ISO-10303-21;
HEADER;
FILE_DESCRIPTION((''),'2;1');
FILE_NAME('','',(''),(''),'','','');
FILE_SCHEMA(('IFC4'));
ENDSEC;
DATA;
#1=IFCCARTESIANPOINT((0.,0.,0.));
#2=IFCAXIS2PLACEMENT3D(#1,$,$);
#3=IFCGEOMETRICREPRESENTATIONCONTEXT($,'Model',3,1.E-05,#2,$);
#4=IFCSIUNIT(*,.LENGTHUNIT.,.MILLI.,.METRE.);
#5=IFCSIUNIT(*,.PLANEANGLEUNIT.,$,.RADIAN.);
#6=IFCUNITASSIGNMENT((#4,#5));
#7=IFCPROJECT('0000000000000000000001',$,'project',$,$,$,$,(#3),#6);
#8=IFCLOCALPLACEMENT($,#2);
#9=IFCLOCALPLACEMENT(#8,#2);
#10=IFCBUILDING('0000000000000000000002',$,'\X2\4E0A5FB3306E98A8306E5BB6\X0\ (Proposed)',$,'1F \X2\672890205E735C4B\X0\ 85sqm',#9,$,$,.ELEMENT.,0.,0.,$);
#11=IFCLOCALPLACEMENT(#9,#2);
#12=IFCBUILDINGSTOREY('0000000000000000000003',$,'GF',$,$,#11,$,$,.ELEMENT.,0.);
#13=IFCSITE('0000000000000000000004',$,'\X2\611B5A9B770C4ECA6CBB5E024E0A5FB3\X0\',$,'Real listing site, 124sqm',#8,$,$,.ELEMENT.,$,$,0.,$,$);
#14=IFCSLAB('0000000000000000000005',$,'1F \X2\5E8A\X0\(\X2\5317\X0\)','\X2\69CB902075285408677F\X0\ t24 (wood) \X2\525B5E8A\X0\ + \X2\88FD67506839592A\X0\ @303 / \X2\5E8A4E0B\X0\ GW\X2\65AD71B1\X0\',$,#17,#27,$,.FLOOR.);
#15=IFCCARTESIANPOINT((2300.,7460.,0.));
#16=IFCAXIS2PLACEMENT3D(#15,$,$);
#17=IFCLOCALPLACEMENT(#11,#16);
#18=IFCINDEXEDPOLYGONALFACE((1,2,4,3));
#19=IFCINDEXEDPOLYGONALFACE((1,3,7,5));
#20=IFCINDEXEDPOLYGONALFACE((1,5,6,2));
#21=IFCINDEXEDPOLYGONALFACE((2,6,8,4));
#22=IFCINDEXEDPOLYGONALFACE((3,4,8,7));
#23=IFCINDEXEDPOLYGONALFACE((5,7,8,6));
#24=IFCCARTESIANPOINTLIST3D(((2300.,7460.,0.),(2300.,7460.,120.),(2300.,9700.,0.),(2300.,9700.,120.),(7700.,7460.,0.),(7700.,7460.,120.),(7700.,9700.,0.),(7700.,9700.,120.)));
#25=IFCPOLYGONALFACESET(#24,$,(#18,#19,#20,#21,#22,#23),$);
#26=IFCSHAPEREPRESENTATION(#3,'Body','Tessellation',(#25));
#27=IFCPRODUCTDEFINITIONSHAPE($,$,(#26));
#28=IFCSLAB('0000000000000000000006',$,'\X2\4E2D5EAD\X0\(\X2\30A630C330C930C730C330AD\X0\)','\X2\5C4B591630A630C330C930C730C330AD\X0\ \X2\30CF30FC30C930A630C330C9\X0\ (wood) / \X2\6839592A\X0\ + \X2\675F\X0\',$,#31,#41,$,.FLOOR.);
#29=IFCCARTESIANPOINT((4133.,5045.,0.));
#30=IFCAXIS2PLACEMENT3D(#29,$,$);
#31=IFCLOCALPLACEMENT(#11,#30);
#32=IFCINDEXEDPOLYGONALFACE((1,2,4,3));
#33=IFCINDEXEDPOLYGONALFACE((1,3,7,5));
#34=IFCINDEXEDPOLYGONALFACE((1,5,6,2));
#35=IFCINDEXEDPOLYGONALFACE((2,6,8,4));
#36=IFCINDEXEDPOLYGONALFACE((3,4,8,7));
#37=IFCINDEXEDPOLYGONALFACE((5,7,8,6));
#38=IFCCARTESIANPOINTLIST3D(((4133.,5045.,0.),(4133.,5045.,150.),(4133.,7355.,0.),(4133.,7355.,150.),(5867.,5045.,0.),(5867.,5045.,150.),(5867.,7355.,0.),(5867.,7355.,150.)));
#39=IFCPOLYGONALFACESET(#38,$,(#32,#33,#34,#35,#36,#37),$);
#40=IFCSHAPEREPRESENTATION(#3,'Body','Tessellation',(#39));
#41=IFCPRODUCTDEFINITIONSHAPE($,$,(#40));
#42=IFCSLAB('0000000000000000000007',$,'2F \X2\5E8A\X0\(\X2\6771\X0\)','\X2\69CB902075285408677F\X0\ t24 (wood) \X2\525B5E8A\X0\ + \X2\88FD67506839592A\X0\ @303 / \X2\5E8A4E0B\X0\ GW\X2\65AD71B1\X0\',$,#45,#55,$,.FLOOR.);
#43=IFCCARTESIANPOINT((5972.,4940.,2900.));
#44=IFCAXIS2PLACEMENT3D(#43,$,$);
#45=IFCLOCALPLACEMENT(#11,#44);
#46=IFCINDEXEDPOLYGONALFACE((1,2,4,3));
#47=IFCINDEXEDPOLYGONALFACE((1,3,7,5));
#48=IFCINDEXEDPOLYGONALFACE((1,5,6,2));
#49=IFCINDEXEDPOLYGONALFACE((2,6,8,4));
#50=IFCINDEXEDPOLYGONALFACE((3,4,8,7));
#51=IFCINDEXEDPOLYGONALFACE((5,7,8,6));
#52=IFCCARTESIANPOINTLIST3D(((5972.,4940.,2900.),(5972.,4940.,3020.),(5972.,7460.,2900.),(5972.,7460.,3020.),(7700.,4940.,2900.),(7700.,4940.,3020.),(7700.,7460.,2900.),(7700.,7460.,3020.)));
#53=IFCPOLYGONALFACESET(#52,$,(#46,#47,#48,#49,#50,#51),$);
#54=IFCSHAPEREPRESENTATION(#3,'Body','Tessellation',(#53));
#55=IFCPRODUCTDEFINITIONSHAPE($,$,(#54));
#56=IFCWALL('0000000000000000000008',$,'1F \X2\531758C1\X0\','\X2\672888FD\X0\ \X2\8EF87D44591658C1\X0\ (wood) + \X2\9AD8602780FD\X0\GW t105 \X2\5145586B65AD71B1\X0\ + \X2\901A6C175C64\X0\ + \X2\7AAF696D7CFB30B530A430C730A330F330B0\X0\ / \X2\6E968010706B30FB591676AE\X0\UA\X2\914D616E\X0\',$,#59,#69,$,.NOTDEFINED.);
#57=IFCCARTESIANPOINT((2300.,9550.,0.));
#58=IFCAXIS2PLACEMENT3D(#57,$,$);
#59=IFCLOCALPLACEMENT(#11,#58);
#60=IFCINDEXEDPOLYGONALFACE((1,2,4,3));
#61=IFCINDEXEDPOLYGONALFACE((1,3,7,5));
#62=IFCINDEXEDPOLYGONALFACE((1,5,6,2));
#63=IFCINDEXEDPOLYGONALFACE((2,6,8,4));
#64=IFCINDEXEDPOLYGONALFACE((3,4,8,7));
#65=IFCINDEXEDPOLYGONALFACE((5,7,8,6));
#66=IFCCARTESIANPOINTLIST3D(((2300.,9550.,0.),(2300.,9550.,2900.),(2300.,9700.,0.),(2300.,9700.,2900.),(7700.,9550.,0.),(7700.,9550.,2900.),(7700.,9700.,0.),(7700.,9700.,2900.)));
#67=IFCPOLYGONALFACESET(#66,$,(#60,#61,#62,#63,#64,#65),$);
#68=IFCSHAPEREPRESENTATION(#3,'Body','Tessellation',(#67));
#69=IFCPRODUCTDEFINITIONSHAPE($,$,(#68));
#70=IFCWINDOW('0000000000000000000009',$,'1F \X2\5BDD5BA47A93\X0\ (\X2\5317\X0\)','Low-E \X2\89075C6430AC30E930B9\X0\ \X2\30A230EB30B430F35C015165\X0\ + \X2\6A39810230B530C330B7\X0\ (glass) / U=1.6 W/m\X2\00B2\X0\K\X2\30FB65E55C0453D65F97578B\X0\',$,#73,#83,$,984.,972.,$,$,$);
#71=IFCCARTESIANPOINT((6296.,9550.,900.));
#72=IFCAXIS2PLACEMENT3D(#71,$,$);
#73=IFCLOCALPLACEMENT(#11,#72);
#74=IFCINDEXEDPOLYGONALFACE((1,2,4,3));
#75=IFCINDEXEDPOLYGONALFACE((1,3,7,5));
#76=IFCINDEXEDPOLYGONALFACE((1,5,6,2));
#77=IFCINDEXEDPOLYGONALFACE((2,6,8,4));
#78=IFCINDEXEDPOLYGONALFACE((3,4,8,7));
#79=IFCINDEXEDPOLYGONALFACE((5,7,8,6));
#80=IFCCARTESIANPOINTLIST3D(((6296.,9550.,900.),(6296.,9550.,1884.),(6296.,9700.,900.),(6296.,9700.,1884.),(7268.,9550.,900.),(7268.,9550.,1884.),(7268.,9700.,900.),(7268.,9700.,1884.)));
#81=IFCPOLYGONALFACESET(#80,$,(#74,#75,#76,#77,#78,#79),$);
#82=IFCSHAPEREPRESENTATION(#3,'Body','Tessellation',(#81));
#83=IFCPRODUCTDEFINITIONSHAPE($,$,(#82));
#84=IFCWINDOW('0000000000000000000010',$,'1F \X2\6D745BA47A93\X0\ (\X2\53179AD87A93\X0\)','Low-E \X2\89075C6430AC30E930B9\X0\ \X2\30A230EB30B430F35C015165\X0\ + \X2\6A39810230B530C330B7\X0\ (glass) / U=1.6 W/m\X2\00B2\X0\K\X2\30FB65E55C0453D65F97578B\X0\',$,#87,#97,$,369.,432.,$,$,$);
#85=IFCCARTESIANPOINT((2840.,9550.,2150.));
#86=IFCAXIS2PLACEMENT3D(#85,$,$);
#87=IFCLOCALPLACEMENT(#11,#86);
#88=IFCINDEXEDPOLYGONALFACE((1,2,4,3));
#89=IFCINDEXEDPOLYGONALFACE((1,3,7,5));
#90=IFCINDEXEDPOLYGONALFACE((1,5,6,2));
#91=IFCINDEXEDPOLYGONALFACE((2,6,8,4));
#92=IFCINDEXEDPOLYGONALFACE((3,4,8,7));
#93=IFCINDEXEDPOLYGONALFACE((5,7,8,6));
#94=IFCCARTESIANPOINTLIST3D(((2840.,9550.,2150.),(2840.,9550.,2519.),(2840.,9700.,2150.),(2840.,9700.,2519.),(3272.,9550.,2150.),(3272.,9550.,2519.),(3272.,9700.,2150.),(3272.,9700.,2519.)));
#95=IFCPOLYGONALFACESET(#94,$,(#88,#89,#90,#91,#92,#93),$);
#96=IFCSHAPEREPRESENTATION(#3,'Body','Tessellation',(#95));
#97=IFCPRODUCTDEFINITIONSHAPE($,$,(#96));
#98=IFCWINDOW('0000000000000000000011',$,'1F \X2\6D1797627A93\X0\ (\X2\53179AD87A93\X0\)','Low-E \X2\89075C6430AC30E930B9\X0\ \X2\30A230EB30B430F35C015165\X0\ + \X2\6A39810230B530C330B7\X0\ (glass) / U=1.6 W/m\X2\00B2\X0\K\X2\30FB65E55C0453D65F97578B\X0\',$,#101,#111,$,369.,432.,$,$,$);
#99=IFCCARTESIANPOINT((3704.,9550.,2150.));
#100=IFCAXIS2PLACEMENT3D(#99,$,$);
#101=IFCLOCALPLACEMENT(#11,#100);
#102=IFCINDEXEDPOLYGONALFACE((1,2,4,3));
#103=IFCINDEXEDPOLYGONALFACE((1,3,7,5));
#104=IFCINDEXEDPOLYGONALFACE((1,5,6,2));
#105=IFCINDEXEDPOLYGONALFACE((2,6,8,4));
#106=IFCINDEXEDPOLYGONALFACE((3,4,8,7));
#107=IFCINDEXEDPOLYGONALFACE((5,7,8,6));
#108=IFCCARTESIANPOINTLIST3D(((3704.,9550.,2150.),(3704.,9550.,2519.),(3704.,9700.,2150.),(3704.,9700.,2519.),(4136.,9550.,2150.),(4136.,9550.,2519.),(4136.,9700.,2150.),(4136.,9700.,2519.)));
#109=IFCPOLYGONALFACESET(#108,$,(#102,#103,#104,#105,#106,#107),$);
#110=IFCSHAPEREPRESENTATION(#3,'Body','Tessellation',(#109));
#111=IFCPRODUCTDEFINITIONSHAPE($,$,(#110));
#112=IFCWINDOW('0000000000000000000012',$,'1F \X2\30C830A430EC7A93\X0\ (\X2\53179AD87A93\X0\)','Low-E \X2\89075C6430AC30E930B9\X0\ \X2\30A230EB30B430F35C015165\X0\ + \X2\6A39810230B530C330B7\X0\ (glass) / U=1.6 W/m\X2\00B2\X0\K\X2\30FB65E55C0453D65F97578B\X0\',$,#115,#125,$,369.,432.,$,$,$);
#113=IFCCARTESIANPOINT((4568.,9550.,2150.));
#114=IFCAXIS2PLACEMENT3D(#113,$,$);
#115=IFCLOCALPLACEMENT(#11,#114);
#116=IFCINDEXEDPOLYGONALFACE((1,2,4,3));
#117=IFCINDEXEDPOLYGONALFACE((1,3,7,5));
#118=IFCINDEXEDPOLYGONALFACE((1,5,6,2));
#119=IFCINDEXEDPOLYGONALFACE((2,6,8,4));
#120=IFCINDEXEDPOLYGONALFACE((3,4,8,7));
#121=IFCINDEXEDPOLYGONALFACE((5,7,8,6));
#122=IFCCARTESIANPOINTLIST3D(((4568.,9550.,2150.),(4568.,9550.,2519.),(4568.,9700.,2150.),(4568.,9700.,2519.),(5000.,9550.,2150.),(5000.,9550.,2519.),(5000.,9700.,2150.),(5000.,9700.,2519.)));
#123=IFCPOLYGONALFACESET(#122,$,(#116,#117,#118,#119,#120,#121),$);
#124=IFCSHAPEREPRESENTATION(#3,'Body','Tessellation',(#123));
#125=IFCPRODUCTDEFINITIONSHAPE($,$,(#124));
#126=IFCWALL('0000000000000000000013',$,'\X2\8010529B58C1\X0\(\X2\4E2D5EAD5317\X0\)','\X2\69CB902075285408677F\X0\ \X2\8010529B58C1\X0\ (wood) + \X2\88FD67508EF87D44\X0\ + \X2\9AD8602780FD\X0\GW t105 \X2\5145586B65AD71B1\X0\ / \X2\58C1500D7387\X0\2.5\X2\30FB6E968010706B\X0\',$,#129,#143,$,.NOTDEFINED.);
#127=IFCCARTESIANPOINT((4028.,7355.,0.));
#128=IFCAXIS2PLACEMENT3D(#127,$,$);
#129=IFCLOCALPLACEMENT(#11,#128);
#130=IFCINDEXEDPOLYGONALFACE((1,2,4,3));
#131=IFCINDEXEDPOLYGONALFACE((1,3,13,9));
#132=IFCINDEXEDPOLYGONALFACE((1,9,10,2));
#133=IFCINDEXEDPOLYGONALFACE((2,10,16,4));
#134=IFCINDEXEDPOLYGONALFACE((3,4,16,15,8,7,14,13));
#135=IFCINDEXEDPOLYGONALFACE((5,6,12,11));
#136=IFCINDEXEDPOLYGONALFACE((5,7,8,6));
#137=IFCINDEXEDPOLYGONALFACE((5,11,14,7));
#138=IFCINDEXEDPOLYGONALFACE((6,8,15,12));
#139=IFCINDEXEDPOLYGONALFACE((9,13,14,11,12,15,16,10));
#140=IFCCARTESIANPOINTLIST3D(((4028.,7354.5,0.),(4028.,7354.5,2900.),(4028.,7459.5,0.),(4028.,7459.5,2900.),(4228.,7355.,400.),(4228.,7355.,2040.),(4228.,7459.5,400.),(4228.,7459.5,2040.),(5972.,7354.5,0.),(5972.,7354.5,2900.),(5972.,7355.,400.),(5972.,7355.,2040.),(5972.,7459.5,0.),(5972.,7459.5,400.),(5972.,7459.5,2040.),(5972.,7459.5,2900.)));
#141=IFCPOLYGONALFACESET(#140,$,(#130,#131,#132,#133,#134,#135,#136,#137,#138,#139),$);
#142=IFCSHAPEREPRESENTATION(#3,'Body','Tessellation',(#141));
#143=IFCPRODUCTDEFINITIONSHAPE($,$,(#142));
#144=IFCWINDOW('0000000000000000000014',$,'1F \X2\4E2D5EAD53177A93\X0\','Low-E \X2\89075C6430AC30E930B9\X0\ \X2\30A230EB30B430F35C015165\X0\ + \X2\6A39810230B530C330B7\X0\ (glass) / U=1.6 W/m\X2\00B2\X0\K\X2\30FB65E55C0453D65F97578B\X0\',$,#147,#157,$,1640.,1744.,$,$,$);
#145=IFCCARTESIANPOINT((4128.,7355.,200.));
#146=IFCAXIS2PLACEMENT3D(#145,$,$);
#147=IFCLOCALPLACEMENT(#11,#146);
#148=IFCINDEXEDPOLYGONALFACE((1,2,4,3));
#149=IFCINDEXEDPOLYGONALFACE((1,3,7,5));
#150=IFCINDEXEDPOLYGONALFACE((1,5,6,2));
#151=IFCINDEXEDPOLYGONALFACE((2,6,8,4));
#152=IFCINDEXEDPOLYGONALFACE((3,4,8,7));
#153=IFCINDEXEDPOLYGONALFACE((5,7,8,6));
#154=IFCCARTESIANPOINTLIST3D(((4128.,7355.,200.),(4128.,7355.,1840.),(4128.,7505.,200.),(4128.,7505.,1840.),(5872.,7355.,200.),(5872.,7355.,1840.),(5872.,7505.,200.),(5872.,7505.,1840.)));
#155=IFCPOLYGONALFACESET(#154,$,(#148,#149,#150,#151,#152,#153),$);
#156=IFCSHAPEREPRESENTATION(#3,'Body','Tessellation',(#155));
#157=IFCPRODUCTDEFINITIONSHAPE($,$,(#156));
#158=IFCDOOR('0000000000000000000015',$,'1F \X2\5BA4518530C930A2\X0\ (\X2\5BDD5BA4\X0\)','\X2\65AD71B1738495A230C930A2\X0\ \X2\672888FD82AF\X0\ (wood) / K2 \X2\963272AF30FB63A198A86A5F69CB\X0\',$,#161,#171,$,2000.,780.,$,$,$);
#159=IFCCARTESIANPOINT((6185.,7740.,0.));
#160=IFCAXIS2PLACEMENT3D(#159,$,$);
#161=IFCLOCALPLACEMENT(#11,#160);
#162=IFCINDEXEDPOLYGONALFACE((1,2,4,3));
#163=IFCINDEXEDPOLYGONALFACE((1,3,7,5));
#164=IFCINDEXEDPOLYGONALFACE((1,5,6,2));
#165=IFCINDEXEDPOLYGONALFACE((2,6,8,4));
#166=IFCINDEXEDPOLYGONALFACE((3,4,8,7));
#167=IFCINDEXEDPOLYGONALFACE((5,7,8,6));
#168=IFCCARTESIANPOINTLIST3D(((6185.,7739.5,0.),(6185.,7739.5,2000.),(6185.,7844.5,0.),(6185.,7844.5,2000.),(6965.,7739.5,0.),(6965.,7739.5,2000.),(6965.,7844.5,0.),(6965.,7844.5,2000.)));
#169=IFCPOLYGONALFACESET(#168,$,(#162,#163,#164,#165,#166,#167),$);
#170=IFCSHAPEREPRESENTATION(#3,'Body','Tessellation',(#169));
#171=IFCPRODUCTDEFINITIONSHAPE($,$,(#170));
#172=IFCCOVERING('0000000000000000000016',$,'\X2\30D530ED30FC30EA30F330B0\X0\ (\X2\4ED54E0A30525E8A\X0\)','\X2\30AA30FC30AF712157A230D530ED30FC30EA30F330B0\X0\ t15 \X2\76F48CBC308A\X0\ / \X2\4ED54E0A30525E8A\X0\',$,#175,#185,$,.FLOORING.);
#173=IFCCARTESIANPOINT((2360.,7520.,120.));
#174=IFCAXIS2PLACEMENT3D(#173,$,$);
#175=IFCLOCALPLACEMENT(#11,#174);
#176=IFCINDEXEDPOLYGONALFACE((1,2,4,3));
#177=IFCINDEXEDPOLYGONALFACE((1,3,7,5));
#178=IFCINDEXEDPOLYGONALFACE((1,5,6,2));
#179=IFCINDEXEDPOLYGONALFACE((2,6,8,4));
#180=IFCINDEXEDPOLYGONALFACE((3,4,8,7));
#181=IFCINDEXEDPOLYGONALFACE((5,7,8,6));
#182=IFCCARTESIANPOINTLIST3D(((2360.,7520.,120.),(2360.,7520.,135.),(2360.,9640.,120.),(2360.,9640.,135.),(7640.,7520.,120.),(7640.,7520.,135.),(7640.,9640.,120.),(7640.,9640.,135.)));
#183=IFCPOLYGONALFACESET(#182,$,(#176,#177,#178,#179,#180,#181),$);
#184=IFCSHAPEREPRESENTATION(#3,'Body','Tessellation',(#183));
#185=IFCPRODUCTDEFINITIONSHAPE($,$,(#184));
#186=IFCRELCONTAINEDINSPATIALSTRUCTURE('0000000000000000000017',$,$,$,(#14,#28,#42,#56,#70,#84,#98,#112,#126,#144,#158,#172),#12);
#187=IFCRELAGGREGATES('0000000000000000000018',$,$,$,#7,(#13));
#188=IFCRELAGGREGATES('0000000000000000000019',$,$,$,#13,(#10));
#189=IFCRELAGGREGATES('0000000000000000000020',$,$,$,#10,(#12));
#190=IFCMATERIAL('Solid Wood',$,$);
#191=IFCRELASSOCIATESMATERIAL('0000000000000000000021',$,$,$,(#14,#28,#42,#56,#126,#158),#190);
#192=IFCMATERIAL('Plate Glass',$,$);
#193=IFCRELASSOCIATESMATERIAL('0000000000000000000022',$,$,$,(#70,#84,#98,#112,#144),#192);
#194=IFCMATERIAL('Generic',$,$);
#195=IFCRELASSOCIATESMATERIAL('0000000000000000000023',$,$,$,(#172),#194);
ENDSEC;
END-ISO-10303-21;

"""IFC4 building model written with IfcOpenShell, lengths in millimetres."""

from ifc_helpers import new_model, si_unit, frame, frame_2d, origin, place, context, project, spatial, rectangle, extrude, material, element, fill, save


model = new_model("IFC4")

# Units and contexts
model_context = context("Model", 3, precision=1e-05, world=origin())
ifc_project = project(units=[si_unit("LENGTHUNIT", "METRE", prefix="MILLI"), si_unit("PLANEANGLEUNIT", "RADIAN")], contexts=[model_context])

# Site, building, storey
site_placement = place(None, origin())
site = spatial("IfcSite", under=ifc_project, at=site_placement, Name="愛媛県今治市上徳", ObjectType="Real listing site, 124sqm", CompositionType="ELEMENT", RefElevation=0.0)
building_placement = place(site_placement, origin())
building = spatial("IfcBuilding", under=site, at=building_placement, Name="上徳の風の家 (Proposed)", ObjectType="1F 木造平屋 85sqm", CompositionType="ELEMENT", ElevationOfRefHeight=0.0, ElevationOfTerrain=0.0)
storey_placement = place(building_placement, origin())
storey = spatial("IfcBuildingStorey", under=building, at=storey_placement, Name="GF", CompositionType="ELEMENT", Elevation=0.0)

# Slabs
ifc_material_1 = material(Name="Solid Wood")
slab_1_placement = place(storey_placement, frame((2300.0, 7460.0, 0.0)))
element("IfcSlab", 1, at=slab_1_placement, inside=storey, material=ifc_material_1, Name="1F 床(北)", Description="構造用合板 t24 (wood) 剛床 + 製材根太 @303 / 床下 GW断熱", PredefinedType="FLOOR", context=model_context, shape_type="SweptSolid", body=[
    extrude(rectangle(XDim=5400.0, YDim=2240.0, at=frame_2d((2700.0, 1120.0))), frame((2300.0, 7460.0, 0.0)), (0.0, 0.0, 1.0), 120.0),
])
slab_2_placement = place(storey_placement, frame((4133.0, 5045.0, 0.0)))
element("IfcSlab", 2, at=slab_2_placement, inside=storey, material=ifc_material_1, Name="中庭(ウッドデッキ)", Description="屋外ウッドデッキ ハードウッド (wood) / 根太 + 束", PredefinedType="FLOOR", context=model_context, shape_type="SweptSolid", body=[
    extrude(rectangle(XDim=1734.0, YDim=2310.0, at=frame_2d((867.0, 1155.0))), frame((4133.0, 5045.0, 0.0)), (0.0, 0.0, 1.0), 150.0),
])
slab_3_placement = place(storey_placement, frame((5972.0, 4940.0, 2900.0)))
element("IfcSlab", 3, at=slab_3_placement, inside=storey, material=ifc_material_1, Name="2F 床(東)", Description="構造用合板 t24 (wood) 剛床 + 製材根太 @303 / 床下 GW断熱", PredefinedType="FLOOR", context=model_context, shape_type="SweptSolid", body=[
    extrude(rectangle(XDim=1728.0, YDim=2520.0, at=frame_2d((864.0, 1260.0))), frame((5972.0, 4940.0, 2900.0)), (0.0, 0.0, 1.0), 120.0),
])

# Wall, openings, windows
wall_1_placement = place(storey_placement, frame((2300.0, 9550.0, 0.0)))
wall_1 = element("IfcWall", 4, at=wall_1_placement, inside=storey, material=ifc_material_1, Name="1F 北壁", Description="木製 軸組外壁 (wood) + 高性能GW t105 充填断熱 + 通気層 + 窯業系サイディング / 準耐火・外皮UA配慮", PredefinedType="NOTDEFINED", context=model_context, shape_type="SweptSolid", body=[
    extrude(rectangle(XDim=5400.0, YDim=150.0, at=frame_2d((2700.0, 75.0))), frame((2300.0, 9550.0, 0.0)), (0.0, 0.0, 1.0), 2900.0),
])
opening_1_placement = place(storey_placement, frame((6296.0, 9550.0, 900.0)))
opening_1 = element("IfcOpeningElement", 5, at=opening_1_placement, cuts=wall_1, PredefinedType="NOTDEFINED", context=model_context, shape_type="SweptSolid", body=[
    extrude(rectangle(XDim=972.0, YDim=150.0, at=frame_2d((486.0, 75.0))), frame((6296.0, 9550.0, 900.0)), (0.0, 0.0, 1.0), 984.0),
])
opening_2_placement = place(storey_placement, frame((2840.0, 9550.0, 2150.0)))
opening_2 = element("IfcOpeningElement", 6, at=opening_2_placement, cuts=wall_1, PredefinedType="NOTDEFINED", context=model_context, shape_type="SweptSolid", body=[
    extrude(rectangle(XDim=432.0, YDim=150.0, at=frame_2d((216.0, 75.0))), frame((2840.0, 9550.0, 2150.0)), (0.0, 0.0, 1.0), 369.0),
])
opening_3_placement = place(storey_placement, frame((3704.0, 9550.0, 2150.0)))
opening_3 = element("IfcOpeningElement", 7, at=opening_3_placement, cuts=wall_1, PredefinedType="NOTDEFINED", context=model_context, shape_type="SweptSolid", body=[
    extrude(rectangle(XDim=432.0, YDim=150.0, at=frame_2d((216.0, 75.0))), frame((3704.0, 9550.0, 2150.0)), (0.0, 0.0, 1.0), 369.0),
])
opening_4_placement = place(storey_placement, frame((4568.0, 9550.0, 2150.0)))
opening_4 = element("IfcOpeningElement", 8, at=opening_4_placement, cuts=wall_1, PredefinedType="NOTDEFINED", context=model_context, shape_type="SweptSolid", body=[
    extrude(rectangle(XDim=432.0, YDim=150.0, at=frame_2d((216.0, 75.0))), frame((4568.0, 9550.0, 2150.0)), (0.0, 0.0, 1.0), 369.0),
])
ifc_material_2 = material(Name="Plate Glass")
window_1_placement = place(storey_placement, frame((6296.0, 9550.0, 900.0)))
window_1 = element("IfcWindow", 9, at=window_1_placement, inside=storey, material=ifc_material_2, Name="1F 寝室窓 (北)", Description="Low-E 複層ガラス アルゴン封入 + 樹脂サッシ (glass) / U=1.6 W/m²K・日射取得型", OverallHeight=984.0, OverallWidth=972.0, context=model_context, shape_type="SweptSolid", body=[
    extrude(rectangle(XDim=972.0, YDim=150.0, at=frame_2d((486.0, 75.0))), frame((6296.0, 9550.0, 900.0)), (0.0, 0.0, 1.0), 984.0),
])
fill(opening_1, window_1)
window_2_placement = place(storey_placement, frame((2840.0, 9550.0, 2150.0)))
window_2 = element("IfcWindow", 10, at=window_2_placement, inside=storey, material=ifc_material_2, Name="1F 浴室窓 (北高窓)", Description="Low-E 複層ガラス アルゴン封入 + 樹脂サッシ (glass) / U=1.6 W/m²K・日射取得型", OverallHeight=369.0, OverallWidth=432.0, context=model_context, shape_type="SweptSolid", body=[
    extrude(rectangle(XDim=432.0, YDim=150.0, at=frame_2d((216.0, 75.0))), frame((2840.0, 9550.0, 2150.0)), (0.0, 0.0, 1.0), 369.0),
])
fill(opening_2, window_2)
window_3_placement = place(storey_placement, frame((3704.0, 9550.0, 2150.0)))
window_3 = element("IfcWindow", 11, at=window_3_placement, inside=storey, material=ifc_material_2, Name="1F 洗面窓 (北高窓)", Description="Low-E 複層ガラス アルゴン封入 + 樹脂サッシ (glass) / U=1.6 W/m²K・日射取得型", OverallHeight=369.0, OverallWidth=432.0, context=model_context, shape_type="SweptSolid", body=[
    extrude(rectangle(XDim=432.0, YDim=150.0, at=frame_2d((216.0, 75.0))), frame((3704.0, 9550.0, 2150.0)), (0.0, 0.0, 1.0), 369.0),
])
fill(opening_3, window_3)
window_4_placement = place(storey_placement, frame((4568.0, 9550.0, 2150.0)))
window_4 = element("IfcWindow", 12, at=window_4_placement, inside=storey, material=ifc_material_2, Name="1F トイレ窓 (北高窓)", Description="Low-E 複層ガラス アルゴン封入 + 樹脂サッシ (glass) / U=1.6 W/m²K・日射取得型", OverallHeight=369.0, OverallWidth=432.0, context=model_context, shape_type="SweptSolid", body=[
    extrude(rectangle(XDim=432.0, YDim=150.0, at=frame_2d((216.0, 75.0))), frame((4568.0, 9550.0, 2150.0)), (0.0, 0.0, 1.0), 369.0),
])
fill(opening_4, window_4)

# Wall, opening, window
wall_2_placement = place(storey_placement, frame((4028.0, 7355.0, 0.0)))
wall_2 = element("IfcWall", 13, at=wall_2_placement, inside=storey, material=ifc_material_1, Name="耐力壁(中庭北)", Description="構造用合板 耐力壁 (wood) + 製材軸組 + 高性能GW t105 充填断熱 / 壁倍率2.5・準耐火", PredefinedType="NOTDEFINED", context=model_context, shape_type="SweptSolid", body=[
    extrude(rectangle(XDim=1944.0, YDim=105.0, at=frame_2d((972.0, 52.0))), frame((4028.0, 7355.0, 0.0)), (0.0, 0.0, 1.0), 2900.0),
])
opening_5_placement = place(storey_placement, frame((4128.0, 7355.0, 200.0)))
opening_5 = element("IfcOpeningElement", 14, at=opening_5_placement, cuts=wall_2, PredefinedType="NOTDEFINED", context=model_context, shape_type="SweptSolid", body=[
    extrude(rectangle(XDim=1744.0, YDim=150.0, at=frame_2d((872.0, 75.0))), frame((4128.0, 7355.0, 200.0)), (0.0, 0.0, 1.0), 1640.0),
])
window_5_placement = place(storey_placement, frame((4128.0, 7355.0, 200.0)))
window_5 = element("IfcWindow", 15, at=window_5_placement, inside=storey, material=ifc_material_2, Name="1F 中庭北窓", Description="Low-E 複層ガラス アルゴン封入 + 樹脂サッシ (glass) / U=1.6 W/m²K・日射取得型", OverallHeight=1640.0, OverallWidth=1744.0, context=model_context, shape_type="SweptSolid", body=[
    extrude(rectangle(XDim=1744.0, YDim=150.0, at=frame_2d((872.0, 75.0))), frame((4128.0, 7355.0, 200.0)), (0.0, 0.0, 1.0), 1640.0),
])
fill(opening_5, window_5)

# Door
door_1_placement = place(storey_placement, frame((6185.0, 7740.0, 0.0)))
element("IfcDoor", 16, at=door_1_placement, inside=storey, material=ifc_material_1, Name="1F 室内ドア (寝室)", Description="断熱玄関ドア 木製芯 (wood) / K2 防犯・採風機構", OverallHeight=2000.0, OverallWidth=780.0, context=model_context, shape_type="SweptSolid", body=[
    extrude(rectangle(XDim=780.0, YDim=105.0, at=frame_2d((390.0, 52.0))), frame((6185.0, 7740.0, 0.0)), (0.0, 0.0, 1.0), 2000.0),
])

# Covering
ifc_material_3 = material(Name="Generic")
covering_1_placement = place(storey_placement, frame((2360.0, 7520.0, 120.0)))
element("IfcCovering", 17, at=covering_1_placement, inside=storey, material=ifc_material_3, Name="フローリング (仕上げ床)", Description="オーク無垢フローリング t15 直貼り / 仕上げ床", PredefinedType="FLOORING", context=model_context, shape_type="SweptSolid", body=[
    extrude(rectangle(XDim=5280.0, YDim=2120.0, at=frame_2d((2640.0, 1060.0))), frame((2360.0, 7520.0, 120.0)), (0.0, 0.0, 1.0), 15.0),
])

save(model, "model.ifc")
